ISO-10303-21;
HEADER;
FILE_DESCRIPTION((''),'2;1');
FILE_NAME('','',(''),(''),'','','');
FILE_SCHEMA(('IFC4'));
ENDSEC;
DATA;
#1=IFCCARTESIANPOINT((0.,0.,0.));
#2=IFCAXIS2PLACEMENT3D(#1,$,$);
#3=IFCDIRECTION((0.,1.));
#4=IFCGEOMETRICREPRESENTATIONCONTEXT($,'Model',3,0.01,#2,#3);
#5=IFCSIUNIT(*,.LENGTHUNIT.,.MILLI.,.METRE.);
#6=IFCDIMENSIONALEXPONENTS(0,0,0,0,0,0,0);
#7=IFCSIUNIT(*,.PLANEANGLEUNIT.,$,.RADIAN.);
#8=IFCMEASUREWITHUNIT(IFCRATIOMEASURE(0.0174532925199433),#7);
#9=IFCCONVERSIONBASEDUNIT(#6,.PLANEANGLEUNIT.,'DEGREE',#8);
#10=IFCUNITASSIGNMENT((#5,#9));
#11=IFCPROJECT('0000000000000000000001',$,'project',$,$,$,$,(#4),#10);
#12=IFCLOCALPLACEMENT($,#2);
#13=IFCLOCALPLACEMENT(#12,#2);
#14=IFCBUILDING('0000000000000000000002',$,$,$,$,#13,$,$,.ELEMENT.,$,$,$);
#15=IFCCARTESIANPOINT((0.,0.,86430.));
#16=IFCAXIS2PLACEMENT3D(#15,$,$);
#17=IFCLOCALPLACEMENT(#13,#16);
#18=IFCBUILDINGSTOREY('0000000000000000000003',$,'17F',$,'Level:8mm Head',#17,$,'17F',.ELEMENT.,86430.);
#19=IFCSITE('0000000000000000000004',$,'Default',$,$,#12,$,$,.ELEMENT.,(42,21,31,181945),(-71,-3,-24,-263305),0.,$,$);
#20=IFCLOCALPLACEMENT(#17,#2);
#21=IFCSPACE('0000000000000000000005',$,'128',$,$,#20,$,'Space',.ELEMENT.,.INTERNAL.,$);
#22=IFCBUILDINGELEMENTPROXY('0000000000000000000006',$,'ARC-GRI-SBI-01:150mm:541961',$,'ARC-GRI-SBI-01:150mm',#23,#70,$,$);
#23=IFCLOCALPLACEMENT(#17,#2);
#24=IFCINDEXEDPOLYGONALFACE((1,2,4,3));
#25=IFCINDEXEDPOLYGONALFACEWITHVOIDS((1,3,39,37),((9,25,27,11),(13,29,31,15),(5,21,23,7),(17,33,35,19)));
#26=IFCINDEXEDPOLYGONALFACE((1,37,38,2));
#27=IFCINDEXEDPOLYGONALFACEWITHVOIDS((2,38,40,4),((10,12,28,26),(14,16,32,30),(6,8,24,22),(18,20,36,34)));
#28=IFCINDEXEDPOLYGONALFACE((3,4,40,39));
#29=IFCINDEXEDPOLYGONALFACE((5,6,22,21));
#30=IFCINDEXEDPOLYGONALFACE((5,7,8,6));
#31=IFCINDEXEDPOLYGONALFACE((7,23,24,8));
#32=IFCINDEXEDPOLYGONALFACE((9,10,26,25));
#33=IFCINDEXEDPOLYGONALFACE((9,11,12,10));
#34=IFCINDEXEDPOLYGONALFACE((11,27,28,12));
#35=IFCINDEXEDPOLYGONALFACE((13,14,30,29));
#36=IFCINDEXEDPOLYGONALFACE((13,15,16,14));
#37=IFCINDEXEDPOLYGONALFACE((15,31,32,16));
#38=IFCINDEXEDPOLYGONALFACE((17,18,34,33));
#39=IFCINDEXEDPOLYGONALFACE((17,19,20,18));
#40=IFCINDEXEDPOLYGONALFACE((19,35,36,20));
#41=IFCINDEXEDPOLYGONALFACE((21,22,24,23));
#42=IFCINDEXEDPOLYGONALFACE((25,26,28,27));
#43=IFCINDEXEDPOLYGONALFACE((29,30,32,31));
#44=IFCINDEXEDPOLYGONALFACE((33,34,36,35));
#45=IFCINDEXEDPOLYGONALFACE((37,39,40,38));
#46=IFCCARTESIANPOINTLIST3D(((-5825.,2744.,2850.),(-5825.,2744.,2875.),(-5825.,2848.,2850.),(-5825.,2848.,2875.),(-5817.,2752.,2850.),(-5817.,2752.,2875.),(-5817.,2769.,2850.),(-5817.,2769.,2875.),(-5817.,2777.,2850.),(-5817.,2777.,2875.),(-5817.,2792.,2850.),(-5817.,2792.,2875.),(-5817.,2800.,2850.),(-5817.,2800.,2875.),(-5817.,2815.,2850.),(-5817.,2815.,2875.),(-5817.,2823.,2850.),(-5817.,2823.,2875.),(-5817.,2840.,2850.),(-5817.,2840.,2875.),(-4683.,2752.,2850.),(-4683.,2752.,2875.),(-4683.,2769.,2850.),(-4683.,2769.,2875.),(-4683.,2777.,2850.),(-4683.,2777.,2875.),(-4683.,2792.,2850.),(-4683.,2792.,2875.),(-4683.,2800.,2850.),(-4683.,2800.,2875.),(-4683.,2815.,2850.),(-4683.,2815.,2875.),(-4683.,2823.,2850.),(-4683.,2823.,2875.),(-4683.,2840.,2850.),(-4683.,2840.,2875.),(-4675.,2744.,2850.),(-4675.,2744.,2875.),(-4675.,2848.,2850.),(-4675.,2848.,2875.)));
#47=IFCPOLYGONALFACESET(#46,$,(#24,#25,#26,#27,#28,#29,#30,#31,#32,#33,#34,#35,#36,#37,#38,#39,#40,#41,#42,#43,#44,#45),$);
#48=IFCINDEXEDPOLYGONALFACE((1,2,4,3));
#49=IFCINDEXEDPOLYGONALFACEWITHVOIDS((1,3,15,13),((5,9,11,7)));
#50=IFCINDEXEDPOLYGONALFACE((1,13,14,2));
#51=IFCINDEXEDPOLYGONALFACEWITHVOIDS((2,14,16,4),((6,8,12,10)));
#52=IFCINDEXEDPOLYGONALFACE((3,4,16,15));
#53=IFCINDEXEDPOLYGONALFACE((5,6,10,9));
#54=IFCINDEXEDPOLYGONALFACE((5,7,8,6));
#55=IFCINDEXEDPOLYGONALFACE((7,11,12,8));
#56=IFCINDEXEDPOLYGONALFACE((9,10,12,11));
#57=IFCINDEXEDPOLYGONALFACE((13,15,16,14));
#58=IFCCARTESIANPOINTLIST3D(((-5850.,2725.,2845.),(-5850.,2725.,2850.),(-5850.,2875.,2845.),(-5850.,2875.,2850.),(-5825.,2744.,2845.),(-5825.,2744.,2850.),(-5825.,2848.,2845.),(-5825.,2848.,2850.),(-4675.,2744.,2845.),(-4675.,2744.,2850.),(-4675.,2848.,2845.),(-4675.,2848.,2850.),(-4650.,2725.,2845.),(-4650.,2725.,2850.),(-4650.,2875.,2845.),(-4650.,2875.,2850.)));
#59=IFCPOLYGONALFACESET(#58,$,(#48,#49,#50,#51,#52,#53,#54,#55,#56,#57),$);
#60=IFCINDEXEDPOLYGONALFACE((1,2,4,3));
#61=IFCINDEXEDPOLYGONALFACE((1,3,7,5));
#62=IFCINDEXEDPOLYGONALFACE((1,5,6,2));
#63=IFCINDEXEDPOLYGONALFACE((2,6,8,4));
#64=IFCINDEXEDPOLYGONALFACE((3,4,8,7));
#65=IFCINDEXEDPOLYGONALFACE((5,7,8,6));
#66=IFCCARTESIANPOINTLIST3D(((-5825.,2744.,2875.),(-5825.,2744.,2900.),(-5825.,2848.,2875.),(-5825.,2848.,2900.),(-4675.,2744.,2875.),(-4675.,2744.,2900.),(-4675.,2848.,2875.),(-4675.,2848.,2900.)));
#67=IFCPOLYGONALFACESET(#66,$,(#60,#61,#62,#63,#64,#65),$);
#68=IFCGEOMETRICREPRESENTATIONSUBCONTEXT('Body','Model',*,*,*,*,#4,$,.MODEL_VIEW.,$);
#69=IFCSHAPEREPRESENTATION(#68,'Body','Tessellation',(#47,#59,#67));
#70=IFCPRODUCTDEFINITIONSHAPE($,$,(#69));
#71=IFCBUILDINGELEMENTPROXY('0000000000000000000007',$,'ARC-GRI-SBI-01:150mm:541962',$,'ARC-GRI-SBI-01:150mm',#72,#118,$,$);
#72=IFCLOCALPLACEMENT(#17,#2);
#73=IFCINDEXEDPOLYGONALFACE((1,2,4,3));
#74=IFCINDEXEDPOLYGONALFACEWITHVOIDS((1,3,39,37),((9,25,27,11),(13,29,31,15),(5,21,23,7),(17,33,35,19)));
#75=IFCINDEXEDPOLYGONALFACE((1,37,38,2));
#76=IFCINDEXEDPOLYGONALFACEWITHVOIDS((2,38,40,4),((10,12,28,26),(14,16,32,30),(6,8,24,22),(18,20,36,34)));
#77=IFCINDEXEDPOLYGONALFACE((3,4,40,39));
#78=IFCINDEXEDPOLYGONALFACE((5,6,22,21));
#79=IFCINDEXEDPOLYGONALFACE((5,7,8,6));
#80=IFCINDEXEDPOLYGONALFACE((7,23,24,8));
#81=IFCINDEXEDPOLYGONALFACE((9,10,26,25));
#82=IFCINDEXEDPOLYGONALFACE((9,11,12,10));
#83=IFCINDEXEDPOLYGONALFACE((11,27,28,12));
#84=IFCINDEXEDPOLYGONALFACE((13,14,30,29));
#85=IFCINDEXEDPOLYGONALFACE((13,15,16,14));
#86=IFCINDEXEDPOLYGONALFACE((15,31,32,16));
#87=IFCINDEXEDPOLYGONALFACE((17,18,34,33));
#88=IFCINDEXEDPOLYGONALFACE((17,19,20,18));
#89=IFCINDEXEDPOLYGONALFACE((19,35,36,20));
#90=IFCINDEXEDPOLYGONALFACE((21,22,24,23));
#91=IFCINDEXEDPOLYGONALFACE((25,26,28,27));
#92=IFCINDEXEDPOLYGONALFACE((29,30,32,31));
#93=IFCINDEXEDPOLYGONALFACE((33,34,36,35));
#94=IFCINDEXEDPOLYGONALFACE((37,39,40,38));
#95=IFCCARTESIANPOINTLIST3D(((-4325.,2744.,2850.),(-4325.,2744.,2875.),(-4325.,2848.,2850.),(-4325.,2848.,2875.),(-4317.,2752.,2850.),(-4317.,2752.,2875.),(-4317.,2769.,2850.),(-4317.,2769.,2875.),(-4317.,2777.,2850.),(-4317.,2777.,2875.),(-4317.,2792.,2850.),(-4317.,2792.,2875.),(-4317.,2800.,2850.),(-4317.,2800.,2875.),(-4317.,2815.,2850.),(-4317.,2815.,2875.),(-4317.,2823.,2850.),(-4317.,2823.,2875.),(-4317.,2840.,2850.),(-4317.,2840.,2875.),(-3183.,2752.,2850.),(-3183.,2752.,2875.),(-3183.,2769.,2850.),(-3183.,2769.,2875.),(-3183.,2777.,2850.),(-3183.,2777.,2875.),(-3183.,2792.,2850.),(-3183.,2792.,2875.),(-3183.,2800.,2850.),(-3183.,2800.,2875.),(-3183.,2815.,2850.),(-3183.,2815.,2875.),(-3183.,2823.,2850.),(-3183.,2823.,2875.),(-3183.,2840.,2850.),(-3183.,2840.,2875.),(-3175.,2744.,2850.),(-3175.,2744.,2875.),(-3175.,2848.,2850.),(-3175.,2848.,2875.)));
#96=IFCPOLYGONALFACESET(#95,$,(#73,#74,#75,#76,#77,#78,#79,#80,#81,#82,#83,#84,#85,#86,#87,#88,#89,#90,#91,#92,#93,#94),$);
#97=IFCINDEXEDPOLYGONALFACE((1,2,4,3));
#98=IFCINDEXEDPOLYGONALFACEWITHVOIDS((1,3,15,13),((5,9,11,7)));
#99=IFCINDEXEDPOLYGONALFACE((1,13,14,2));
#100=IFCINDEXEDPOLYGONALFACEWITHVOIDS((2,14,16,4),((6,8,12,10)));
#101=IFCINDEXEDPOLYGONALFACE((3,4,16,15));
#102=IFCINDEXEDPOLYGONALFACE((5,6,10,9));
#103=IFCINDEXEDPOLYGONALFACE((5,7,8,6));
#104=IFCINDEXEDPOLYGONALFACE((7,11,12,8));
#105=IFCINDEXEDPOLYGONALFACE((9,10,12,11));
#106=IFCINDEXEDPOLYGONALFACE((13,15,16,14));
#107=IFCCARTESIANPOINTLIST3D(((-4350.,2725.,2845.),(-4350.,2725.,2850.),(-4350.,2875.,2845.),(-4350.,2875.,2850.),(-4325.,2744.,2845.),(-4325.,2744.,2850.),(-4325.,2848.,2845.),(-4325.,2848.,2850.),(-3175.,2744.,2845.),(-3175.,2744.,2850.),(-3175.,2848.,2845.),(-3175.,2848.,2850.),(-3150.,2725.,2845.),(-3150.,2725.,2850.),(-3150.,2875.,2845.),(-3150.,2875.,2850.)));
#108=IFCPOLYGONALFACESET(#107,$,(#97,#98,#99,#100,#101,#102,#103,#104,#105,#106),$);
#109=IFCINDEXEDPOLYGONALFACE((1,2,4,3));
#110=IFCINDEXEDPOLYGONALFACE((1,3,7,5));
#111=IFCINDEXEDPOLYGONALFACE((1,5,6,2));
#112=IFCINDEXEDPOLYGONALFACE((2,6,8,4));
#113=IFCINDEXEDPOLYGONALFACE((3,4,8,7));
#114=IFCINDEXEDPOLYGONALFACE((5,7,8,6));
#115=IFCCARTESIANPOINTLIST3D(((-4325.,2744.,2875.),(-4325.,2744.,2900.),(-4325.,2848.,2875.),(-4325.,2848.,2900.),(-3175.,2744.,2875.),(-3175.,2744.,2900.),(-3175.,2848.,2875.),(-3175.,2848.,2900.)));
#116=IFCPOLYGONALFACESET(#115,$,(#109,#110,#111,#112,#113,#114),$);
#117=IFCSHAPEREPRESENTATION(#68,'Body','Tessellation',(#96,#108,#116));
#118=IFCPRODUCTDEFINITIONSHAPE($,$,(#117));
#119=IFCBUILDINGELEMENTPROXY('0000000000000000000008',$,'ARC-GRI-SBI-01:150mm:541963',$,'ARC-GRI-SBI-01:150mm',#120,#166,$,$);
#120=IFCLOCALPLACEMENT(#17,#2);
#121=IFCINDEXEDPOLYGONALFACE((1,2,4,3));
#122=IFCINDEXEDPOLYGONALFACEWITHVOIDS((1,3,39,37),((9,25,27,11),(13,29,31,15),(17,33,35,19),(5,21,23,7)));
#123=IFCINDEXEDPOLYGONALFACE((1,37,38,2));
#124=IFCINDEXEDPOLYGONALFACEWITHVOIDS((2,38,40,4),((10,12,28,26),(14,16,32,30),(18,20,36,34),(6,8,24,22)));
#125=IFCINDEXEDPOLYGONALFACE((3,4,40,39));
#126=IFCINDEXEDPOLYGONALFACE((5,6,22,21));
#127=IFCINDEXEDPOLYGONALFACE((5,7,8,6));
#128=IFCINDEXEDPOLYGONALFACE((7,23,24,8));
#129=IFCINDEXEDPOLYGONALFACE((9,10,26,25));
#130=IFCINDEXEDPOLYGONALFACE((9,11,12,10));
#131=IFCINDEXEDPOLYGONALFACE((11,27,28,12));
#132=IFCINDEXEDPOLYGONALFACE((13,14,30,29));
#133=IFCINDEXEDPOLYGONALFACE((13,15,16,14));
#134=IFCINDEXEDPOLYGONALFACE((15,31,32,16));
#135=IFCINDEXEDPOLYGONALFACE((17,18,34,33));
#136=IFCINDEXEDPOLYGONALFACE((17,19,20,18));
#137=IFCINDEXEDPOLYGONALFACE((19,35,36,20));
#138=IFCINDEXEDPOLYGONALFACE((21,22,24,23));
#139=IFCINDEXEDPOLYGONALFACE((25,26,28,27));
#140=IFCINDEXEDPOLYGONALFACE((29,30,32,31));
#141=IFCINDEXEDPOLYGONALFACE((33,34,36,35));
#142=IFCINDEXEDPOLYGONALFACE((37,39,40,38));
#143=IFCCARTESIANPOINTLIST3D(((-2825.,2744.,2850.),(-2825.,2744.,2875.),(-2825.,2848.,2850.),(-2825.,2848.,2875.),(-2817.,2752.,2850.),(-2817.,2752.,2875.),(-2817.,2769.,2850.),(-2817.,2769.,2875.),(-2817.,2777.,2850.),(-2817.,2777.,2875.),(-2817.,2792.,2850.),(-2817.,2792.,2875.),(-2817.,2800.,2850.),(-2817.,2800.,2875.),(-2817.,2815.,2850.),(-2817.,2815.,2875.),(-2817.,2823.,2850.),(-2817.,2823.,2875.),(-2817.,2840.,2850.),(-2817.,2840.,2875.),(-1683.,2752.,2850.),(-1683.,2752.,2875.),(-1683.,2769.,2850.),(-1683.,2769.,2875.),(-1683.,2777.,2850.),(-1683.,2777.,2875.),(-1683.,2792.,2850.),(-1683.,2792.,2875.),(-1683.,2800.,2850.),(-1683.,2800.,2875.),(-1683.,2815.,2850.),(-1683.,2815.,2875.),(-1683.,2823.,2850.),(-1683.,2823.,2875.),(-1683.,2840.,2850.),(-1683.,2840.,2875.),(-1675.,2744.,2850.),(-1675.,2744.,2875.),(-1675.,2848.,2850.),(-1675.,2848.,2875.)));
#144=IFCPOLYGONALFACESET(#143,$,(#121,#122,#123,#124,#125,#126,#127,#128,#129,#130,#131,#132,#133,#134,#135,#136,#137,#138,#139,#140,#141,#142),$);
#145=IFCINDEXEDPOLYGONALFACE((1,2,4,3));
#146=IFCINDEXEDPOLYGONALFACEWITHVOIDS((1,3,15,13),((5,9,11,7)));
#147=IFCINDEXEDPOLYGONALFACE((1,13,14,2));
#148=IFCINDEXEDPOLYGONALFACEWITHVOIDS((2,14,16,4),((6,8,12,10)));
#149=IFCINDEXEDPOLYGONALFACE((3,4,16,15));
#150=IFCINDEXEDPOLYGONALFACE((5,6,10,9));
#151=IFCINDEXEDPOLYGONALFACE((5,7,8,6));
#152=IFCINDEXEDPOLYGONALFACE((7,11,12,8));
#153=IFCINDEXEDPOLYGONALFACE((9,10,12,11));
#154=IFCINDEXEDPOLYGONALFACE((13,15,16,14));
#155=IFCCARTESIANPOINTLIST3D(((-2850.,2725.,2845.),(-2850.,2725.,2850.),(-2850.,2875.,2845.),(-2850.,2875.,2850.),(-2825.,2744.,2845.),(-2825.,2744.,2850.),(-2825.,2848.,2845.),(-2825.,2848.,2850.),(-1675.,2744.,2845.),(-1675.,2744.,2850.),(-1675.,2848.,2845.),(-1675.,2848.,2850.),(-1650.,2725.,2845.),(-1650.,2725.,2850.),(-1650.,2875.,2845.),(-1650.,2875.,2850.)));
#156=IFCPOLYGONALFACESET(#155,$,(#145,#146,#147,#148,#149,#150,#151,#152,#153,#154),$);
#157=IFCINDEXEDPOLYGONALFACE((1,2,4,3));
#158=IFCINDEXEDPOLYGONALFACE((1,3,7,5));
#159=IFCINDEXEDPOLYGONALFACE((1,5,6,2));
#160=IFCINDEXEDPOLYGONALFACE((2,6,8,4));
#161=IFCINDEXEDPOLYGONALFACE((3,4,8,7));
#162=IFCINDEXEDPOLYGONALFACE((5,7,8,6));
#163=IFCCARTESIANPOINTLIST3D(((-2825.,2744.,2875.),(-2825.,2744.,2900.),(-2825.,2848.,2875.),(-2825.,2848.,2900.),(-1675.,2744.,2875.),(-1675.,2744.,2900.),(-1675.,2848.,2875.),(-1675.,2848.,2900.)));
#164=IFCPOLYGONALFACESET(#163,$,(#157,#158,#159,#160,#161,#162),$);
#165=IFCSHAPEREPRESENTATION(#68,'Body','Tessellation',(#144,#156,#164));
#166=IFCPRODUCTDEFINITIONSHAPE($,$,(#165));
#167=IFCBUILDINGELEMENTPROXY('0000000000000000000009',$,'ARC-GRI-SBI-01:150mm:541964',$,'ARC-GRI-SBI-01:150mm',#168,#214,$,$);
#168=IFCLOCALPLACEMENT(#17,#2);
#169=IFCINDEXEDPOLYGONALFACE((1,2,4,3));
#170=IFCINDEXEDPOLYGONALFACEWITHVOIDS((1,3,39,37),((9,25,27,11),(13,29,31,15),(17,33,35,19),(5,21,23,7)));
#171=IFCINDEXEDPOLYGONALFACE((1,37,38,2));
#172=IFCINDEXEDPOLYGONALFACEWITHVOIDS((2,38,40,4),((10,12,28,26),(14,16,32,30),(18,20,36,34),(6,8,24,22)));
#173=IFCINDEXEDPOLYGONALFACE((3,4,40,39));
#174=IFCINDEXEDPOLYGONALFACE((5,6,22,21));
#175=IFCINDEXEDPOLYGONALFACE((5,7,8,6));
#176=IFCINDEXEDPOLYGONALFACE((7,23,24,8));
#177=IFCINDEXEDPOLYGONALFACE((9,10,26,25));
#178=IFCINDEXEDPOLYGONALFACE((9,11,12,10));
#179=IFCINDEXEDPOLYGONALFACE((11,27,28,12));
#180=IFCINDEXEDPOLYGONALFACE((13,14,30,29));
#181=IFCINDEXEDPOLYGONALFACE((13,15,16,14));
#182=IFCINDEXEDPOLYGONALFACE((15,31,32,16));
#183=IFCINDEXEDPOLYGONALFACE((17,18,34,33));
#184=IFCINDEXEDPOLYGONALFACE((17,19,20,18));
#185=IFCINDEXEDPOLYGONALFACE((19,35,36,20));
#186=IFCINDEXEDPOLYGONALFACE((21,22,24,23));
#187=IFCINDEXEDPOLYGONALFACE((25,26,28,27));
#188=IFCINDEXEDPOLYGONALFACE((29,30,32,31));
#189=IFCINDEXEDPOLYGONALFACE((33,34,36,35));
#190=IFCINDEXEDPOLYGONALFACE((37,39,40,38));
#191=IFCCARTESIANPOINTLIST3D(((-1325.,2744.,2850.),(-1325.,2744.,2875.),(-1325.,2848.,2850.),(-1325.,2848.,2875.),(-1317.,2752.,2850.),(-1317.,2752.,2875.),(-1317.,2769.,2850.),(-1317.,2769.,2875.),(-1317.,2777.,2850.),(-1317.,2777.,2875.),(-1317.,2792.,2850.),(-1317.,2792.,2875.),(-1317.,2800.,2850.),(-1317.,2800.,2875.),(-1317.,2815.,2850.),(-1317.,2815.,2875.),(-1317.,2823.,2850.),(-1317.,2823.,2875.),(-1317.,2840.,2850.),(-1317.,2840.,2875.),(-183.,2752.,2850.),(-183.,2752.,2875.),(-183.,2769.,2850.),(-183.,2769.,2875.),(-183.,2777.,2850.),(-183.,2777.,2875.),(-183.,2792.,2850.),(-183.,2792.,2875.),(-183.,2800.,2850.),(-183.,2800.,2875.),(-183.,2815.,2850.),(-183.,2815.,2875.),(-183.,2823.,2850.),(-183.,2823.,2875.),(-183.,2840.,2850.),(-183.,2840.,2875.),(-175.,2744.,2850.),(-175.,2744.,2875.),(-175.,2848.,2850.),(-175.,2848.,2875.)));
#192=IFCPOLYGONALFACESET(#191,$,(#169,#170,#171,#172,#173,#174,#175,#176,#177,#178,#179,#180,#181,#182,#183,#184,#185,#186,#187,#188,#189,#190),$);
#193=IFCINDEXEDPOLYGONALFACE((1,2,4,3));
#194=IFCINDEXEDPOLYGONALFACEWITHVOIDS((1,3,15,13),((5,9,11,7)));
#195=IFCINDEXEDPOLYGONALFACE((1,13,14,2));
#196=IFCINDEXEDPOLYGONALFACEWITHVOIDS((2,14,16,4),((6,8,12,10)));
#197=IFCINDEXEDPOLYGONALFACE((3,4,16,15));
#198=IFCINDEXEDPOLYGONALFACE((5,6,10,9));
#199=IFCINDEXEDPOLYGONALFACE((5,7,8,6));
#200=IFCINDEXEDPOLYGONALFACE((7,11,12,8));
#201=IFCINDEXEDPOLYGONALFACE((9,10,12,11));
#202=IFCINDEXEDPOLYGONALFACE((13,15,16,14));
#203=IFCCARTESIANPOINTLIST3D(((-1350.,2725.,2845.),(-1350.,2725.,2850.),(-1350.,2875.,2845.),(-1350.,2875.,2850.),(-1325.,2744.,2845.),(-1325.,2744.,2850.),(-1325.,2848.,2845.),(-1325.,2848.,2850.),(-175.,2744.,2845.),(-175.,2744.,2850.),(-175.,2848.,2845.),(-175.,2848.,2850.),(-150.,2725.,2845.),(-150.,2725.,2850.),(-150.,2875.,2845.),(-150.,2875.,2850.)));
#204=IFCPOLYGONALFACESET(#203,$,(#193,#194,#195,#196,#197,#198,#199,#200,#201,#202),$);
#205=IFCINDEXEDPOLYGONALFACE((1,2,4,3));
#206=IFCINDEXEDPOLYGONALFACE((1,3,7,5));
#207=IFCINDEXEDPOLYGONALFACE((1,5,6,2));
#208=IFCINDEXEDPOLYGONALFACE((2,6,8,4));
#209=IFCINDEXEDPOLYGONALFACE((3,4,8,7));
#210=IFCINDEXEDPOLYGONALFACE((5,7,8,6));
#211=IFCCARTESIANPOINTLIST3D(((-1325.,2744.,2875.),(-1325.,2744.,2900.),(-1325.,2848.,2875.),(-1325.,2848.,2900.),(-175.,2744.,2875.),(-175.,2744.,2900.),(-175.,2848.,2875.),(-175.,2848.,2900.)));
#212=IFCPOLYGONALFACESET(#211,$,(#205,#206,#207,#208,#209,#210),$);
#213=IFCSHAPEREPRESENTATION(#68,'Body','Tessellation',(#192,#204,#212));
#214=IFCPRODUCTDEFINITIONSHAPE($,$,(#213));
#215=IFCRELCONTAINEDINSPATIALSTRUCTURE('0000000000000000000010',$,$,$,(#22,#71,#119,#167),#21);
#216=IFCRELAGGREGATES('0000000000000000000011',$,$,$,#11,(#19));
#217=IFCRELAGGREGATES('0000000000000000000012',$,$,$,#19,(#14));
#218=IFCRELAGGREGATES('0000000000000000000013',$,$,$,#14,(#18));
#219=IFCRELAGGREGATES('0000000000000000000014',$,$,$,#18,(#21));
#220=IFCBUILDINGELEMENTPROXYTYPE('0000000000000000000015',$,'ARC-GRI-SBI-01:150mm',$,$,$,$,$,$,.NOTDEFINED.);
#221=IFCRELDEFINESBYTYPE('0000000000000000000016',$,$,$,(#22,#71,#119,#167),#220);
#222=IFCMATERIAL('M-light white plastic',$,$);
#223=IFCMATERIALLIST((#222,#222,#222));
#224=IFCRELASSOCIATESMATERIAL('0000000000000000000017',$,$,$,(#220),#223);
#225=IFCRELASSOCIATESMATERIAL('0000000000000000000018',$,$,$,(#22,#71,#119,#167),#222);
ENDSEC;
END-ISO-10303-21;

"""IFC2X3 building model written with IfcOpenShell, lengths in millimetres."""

from ifc_helpers import new_model, entity, si_unit, converted_unit, direction, frame, origin, origin_2d_with_axis, place, context, subcontext, project, spatial, polyline, rectangle, outline, extrude, source, transform, mapped, material, material_list, type_object, type_shapes, element, save


model = new_model("IFC2X3")

# Units and contexts
model_context = context("Model", 3, precision=0.01, world=origin(), true_north=direction((0.0, 1.0)))
body_context = subcontext(model_context, "Body", "Model", "MODEL_VIEW")
ifc_project = project(units=[si_unit("LENGTHUNIT", "METRE", prefix="MILLI"), converted_unit("PLANEANGLEUNIT", "DEGREE", entity("IfcRatioMeasure", 0.0174532925199433), si_unit("PLANEANGLEUNIT", "RADIAN"), dimensions=[0, 0, 0, 0, 0, 0, 0])], contexts=[model_context])

# Site, building, storey
site_placement = place(None, origin())
site = spatial("IfcSite", under=ifc_project, at=site_placement, Name="Default", CompositionType="ELEMENT", RefLatitude=(42, 21, 31, 181945), RefLongitude=(-71, -3, -24, -263305), RefElevation=0.0)
building_placement = place(site_placement, origin())
building = spatial("IfcBuilding", under=site, at=building_placement, CompositionType="ELEMENT")
storey_placement = place(building_placement, frame((0.0, 0.0, 86430.0)))
storey = spatial("IfcBuildingStorey", under=building, at=storey_placement, Name="17F", ObjectType="Level:8mm Head", LongName="17F", CompositionType="ELEMENT", Elevation=86430.0)

# Shared definitions
space_placement = place(storey_placement, origin())
space = spatial("IfcSpace", under=storey, at=space_placement, Name="128", LongName="Space", CompositionType="ELEMENT", InteriorOrExteriorSpace="INTERNAL")

# Building element proxies
ifc_material_1 = material(Name="M-light white plastic")
ifc_material_list = material_list([ifc_material_1, ifc_material_1, ifc_material_1])
building_element_proxy_type = type_object("IfcBuildingElementProxyType", Name="ARC-GRI-SBI-01:150mm", PredefinedType="NOTDEFINED", material=ifc_material_list)
shared_shape = source(origin(), body_context, "Body", "SweptSolid", [
    extrude(outline(polyline([(-575.0, -52.0), (575.0, -52.0), (575.0, 52.0), (-575.0, 52.0), (-575.0, -52.0)]), holes=[polyline([(-567.0, -44.0), (-567.0, -27.0), (567.0, -27.0), (567.0, -44.0), (-567.0, -44.0)]), polyline([(567.0, -4.0), (567.0, -19.0), (-567.0, -19.0), (-567.0, -4.0), (567.0, -4.0)]), polyline([(-567.0, 44.0), (567.0, 44.0), (567.0, 27.0), (-567.0, 27.0), (-567.0, 44.0)]), polyline([(567.0, 4.0), (-567.0, 4.0), (-567.0, 19.0), (567.0, 19.0), (567.0, 4.0)])]), frame((425.0, 4.0, 4000.0), z_axis=(0.0, 0.0, 1.0), x_axis=(-1.0, 0.0, 0.0)), (0.0, 0.0, 1.0), 25.0),
    extrude(outline(polyline([(-600.0, -75.0), (600.0, -75.0), (600.0, 75.0), (-600.0, 75.0), (-600.0, -75.0)]), holes=[polyline([(-575.0, -56.0), (-575.0, 48.0), (575.0, 48.0), (575.0, -56.0), (-575.0, -56.0)])]), frame((425.0, 0.0, 3995.0), z_axis=(0.0, 0.0, 1.0), x_axis=(-1.0, 0.0, 0.0)), (0.0, 0.0, 1.0), 5.0),
    extrude(rectangle(XDim=1150.0, YDim=104.0, at=origin_2d_with_axis()), frame((425.0, 4.0, 4025.0), z_axis=(0.0, 0.0, 1.0), x_axis=(-1.0, 0.0, 0.0)), (0.0, 0.0, 1.0), 25.0),
])
type_shapes(building_element_proxy_type, [shared_shape])
for number, where, z_axis, x_axis, name in (
    (1, (-4825.0, 2800.0, -1150.0), (0.0, 0.0, 1.0), (-1.0, 0.0, 0.0), "ARC-GRI-SBI-01:150mm:541961"),
    (2, (-3325.0, 2800.0, -1150.0), (0.0, 0.0, 1.0), (-1.0, 0.0, 0.0), "ARC-GRI-SBI-01:150mm:541962"),
    (3, (-1825.0, 2800.0, -1150.0), (0.0, 0.0, 1.0), (-1.0, 0.0, 0.0), "ARC-GRI-SBI-01:150mm:541963"),
    (4, (-325.0, 2800.0, -1150.0), (0.0, 0.0, 1.0), (-1.0, 0.0, 0.0), "ARC-GRI-SBI-01:150mm:541964"),
):
    element("IfcBuildingElementProxy", number, at=place(space_placement, frame(where, z_axis=z_axis, x_axis=x_axis)), inside=space, type_object=building_element_proxy_type, material=ifc_material_1, Name=name, ObjectType="ARC-GRI-SBI-01:150mm", context=body_context, shape_type="MappedRepresentation", body=[
        mapped(shared_shape, transform((0.0, 0.0, 0.0), scale=1.0)),
    ])

save(model, "model.ifc")
